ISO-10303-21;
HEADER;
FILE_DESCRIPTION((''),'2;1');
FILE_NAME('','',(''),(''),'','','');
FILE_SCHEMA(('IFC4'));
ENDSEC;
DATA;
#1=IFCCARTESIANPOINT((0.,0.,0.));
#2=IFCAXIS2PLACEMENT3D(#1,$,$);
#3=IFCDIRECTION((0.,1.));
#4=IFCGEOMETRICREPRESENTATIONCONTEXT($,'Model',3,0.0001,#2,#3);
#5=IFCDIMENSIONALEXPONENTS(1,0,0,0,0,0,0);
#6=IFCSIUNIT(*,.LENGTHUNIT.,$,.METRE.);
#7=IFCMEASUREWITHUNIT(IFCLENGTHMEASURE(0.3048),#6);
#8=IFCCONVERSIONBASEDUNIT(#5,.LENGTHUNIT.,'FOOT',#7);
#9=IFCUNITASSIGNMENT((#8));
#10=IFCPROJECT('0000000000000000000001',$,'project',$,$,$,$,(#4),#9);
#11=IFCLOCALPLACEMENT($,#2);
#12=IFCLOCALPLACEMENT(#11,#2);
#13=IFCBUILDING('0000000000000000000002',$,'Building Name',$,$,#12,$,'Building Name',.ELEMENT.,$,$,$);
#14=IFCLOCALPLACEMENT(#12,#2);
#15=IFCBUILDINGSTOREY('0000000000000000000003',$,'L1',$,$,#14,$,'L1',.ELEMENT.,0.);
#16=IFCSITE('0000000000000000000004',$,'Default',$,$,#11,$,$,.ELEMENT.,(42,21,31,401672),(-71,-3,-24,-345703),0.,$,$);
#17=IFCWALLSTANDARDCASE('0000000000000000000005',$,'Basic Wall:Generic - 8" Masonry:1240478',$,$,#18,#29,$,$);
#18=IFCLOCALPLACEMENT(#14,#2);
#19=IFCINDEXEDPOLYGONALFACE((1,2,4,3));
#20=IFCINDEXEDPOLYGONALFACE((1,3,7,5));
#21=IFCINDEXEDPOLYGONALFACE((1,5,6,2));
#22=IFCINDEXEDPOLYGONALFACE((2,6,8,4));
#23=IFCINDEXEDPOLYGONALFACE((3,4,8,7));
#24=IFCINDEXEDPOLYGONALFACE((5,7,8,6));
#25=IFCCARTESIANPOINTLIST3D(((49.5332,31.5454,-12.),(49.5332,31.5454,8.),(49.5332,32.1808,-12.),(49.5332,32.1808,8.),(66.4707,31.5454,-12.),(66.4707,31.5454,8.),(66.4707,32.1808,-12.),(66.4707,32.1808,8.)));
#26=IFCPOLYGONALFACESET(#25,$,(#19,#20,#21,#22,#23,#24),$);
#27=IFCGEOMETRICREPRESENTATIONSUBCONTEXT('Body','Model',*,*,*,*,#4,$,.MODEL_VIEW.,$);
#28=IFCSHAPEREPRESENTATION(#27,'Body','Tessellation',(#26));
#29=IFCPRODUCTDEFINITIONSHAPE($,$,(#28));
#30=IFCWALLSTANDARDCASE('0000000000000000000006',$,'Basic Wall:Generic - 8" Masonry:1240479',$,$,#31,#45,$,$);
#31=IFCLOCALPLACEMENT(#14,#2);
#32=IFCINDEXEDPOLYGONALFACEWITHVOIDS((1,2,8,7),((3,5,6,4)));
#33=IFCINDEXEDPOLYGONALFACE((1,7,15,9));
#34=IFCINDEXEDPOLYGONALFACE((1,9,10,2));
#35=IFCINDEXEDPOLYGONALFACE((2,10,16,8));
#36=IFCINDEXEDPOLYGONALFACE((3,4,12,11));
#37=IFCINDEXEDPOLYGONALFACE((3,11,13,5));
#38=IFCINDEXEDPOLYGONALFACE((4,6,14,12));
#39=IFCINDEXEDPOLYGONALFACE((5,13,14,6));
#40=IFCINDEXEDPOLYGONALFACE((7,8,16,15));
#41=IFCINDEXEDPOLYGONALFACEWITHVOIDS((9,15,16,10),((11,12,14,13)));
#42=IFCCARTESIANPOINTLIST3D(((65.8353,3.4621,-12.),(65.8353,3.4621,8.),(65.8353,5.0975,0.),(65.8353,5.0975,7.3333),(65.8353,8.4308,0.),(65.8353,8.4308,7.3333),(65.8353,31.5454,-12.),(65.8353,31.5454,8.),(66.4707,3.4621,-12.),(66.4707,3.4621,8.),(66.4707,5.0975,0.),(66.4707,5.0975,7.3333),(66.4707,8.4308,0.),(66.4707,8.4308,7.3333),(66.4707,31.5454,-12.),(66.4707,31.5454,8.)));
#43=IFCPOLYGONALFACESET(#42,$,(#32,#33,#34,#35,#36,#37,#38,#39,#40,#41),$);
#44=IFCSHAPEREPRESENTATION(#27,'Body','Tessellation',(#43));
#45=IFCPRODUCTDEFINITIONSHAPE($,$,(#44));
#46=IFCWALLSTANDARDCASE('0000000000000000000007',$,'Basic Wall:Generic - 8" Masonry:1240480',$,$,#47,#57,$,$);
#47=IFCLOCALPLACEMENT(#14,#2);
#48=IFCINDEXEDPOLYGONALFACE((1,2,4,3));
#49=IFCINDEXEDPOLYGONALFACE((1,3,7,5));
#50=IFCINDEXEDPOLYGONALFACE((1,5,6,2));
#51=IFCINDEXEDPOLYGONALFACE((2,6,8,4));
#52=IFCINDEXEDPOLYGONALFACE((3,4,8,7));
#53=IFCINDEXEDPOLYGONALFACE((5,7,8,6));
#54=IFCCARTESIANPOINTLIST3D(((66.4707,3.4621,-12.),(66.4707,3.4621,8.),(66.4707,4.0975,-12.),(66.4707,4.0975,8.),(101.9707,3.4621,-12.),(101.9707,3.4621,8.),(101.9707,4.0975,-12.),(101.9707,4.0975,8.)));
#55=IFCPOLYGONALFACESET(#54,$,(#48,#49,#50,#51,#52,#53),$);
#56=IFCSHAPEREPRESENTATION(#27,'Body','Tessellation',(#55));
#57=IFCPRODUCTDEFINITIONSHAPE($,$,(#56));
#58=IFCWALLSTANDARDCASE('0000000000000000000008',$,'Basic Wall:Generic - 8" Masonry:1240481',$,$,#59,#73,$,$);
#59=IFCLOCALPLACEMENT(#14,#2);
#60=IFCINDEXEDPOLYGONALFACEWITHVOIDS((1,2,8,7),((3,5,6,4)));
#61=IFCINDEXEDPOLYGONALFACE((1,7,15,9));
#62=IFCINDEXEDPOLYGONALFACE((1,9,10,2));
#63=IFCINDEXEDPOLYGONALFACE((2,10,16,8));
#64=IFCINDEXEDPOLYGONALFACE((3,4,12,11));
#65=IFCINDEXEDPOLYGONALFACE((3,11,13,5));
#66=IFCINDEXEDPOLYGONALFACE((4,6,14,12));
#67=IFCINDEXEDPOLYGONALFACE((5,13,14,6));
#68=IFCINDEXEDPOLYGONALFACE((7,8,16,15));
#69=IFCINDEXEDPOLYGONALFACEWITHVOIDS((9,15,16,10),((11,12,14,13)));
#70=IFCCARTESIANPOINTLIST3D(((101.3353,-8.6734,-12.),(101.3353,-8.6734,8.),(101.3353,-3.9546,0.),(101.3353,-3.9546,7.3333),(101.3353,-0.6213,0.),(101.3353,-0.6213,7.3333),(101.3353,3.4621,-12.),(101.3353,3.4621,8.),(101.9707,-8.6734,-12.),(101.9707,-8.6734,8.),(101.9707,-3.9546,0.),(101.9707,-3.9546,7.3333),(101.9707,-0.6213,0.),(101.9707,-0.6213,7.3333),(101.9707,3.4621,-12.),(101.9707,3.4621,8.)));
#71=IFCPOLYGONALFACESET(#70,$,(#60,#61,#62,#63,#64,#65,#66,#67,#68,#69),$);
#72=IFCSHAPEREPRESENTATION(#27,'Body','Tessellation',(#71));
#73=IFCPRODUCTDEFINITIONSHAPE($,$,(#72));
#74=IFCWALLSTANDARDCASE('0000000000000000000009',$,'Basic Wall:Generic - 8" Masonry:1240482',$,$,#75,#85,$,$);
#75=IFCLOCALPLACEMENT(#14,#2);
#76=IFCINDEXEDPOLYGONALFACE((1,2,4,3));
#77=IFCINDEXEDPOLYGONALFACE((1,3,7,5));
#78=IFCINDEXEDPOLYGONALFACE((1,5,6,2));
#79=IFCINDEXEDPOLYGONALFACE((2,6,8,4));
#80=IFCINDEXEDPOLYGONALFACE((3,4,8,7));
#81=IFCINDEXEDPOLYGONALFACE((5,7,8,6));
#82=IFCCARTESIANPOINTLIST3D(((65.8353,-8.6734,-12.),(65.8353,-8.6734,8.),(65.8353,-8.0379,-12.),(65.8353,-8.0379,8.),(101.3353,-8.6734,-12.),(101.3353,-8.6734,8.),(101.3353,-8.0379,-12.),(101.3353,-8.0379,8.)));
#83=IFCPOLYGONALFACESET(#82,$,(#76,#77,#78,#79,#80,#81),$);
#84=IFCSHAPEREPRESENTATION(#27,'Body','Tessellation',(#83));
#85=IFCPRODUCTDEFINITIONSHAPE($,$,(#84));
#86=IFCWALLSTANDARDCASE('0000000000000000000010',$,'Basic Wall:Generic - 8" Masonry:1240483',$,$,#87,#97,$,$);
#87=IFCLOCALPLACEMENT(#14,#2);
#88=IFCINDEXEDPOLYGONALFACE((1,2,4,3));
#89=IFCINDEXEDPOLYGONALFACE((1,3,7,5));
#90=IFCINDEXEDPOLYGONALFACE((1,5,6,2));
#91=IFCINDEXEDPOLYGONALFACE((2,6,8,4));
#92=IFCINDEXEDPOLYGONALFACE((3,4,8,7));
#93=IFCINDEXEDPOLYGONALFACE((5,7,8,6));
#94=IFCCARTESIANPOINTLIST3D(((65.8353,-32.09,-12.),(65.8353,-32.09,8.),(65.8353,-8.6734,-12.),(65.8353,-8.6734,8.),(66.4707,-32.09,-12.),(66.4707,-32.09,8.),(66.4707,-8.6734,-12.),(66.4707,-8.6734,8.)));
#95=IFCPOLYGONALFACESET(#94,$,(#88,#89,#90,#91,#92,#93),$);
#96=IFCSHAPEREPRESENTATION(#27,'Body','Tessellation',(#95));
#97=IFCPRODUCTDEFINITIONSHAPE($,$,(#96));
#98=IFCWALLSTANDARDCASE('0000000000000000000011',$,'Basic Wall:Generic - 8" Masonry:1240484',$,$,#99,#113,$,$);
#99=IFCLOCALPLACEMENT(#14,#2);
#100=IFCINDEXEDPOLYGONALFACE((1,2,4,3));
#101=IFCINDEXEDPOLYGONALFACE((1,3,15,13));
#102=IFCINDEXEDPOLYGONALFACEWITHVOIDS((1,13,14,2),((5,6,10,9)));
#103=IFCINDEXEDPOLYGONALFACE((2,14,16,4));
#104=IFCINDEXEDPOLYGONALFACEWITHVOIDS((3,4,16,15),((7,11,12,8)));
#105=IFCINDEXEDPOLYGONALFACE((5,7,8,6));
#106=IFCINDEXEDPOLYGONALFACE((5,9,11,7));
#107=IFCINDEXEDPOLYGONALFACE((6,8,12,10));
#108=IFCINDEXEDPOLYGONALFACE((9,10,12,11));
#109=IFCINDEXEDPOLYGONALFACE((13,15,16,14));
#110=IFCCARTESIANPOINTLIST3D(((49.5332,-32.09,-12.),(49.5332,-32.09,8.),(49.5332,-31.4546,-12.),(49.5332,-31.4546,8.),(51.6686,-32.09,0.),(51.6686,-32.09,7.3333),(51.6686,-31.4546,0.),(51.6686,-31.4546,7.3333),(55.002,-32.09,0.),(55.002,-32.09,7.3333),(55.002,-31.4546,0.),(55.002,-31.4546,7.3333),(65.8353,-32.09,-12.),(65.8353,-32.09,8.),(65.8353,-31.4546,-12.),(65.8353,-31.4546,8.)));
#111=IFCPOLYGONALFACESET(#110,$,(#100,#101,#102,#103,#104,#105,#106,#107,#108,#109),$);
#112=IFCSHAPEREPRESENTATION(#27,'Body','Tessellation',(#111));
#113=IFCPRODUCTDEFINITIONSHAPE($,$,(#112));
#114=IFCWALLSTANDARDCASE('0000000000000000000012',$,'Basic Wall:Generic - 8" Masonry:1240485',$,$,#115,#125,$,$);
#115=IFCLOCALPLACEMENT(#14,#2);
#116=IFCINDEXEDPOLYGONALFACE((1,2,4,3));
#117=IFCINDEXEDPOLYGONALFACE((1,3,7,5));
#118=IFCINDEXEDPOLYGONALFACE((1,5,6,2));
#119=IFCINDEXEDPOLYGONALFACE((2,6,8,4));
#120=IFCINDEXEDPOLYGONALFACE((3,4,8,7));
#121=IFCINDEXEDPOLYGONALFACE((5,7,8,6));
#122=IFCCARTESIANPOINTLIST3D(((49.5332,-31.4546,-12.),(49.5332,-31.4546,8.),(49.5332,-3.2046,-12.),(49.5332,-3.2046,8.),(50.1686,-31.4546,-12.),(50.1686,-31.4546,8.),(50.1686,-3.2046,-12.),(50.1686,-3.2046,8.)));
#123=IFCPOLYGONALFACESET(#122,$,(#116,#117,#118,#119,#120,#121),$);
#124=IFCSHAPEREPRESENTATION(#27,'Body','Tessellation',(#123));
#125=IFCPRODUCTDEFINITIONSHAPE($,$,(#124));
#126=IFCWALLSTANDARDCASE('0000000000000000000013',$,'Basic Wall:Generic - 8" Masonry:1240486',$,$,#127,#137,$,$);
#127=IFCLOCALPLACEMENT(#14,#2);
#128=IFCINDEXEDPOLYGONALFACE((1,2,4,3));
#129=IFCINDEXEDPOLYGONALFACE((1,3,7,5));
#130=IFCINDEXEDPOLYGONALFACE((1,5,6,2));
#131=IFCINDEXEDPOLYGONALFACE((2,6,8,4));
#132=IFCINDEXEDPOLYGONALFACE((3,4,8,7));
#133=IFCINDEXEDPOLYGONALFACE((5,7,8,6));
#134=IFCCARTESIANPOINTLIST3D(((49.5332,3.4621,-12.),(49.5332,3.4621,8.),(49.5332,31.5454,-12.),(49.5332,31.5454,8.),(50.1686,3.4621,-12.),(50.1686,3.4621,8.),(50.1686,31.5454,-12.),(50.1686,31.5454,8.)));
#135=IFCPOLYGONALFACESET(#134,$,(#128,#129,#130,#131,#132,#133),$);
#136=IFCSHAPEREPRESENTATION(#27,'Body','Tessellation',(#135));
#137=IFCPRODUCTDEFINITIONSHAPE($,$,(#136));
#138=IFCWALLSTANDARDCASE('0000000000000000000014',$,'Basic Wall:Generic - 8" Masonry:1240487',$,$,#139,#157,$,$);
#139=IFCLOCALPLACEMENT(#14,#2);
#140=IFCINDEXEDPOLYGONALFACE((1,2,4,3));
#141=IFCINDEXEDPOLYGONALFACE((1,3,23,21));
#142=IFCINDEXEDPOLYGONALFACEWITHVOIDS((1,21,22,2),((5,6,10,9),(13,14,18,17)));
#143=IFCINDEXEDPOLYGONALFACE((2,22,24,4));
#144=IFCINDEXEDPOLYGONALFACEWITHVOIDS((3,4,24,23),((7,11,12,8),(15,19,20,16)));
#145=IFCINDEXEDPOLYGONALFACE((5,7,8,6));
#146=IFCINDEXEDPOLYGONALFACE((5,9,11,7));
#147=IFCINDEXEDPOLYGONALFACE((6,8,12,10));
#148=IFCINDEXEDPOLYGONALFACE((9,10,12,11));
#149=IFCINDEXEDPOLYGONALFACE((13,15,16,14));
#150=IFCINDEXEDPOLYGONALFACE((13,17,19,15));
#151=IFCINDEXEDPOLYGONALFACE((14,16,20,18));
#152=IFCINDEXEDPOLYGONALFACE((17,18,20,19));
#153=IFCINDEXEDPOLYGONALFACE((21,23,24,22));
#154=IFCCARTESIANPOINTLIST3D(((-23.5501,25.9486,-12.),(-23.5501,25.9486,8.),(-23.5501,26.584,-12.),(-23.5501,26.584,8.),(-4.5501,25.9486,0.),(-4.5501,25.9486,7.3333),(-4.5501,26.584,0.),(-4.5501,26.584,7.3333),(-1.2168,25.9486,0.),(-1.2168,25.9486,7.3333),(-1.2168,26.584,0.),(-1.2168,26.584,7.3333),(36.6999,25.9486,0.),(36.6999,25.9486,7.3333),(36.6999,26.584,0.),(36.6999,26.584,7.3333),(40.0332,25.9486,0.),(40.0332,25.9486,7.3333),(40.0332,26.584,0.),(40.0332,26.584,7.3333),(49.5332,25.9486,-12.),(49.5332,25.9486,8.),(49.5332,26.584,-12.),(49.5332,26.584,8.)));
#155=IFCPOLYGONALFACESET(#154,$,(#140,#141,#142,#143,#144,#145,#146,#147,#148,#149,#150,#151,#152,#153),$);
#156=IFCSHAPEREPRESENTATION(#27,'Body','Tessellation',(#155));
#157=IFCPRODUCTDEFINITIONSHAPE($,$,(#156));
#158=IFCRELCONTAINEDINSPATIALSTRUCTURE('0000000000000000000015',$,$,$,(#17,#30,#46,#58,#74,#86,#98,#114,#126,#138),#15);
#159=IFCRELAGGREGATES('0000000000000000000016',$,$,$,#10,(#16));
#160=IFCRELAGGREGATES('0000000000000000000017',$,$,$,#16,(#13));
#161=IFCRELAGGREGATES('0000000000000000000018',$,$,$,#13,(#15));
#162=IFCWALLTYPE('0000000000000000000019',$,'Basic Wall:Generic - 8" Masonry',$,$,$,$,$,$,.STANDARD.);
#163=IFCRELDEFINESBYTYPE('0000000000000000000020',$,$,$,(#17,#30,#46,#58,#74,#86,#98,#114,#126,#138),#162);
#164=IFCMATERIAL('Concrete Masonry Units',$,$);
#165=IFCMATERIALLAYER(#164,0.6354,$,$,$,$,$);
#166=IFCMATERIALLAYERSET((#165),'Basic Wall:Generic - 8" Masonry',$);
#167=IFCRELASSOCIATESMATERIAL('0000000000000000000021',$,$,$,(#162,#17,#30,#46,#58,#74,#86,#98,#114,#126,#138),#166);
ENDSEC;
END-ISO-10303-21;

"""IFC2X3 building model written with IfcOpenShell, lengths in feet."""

from ifc_helpers import new_model, entity, si_unit, converted_unit, direction, frame, frame_2d, origin, place, context, subcontext, project, spatial, rectangle, extrude, material, layer, layer_set, layer_usage, type_object, element, save


model = new_model("IFC2X3")

# Units and contexts
model_context = context("Model", 3, precision=0.0001, world=origin(), true_north=direction((0.0, 1.0)))
body_context = subcontext(model_context, "Body", "Model", "MODEL_VIEW")
ifc_project = project(units=[converted_unit("LENGTHUNIT", "FOOT", entity("IfcLengthMeasure", 0.3048), si_unit("LENGTHUNIT", "METRE"), dimensions=[1, 0, 0, 0, 0, 0, 0])], contexts=[model_context])

# Site, building, storey
site_placement = place(None, origin())
site = spatial("IfcSite", under=ifc_project, at=site_placement, Name="Default", CompositionType="ELEMENT", RefLatitude=(42, 21, 31, 401672), RefLongitude=(-71, -3, -24, -345703), RefElevation=0.0)
building_placement = place(site_placement, origin())
building = spatial("IfcBuilding", under=site, at=building_placement, Name="Building Name", LongName="Building Name", CompositionType="ELEMENT")
storey_placement = place(building_placement, origin())
storey = spatial("IfcBuildingStorey", under=building, at=storey_placement, Name="L1", LongName="L1", CompositionType="ELEMENT", Elevation=0.0)

# Wall
ifc_material = material(Name="Concrete Masonry Units")
ifc_layer = layer(ifc_material, 0.6354)
ifc_layer_set = layer_set([ifc_layer], Name="Basic Wall:Generic - 8\" Masonry")
ifc_layer_usage_1 = layer_usage(ifc_layer_set, "AXIS2", "NEGATIVE", 0.3177)
wall_type = type_object("IfcWallType", Name="Basic Wall:Generic - 8\" Masonry", PredefinedType="STANDARD", material=ifc_layer_set)
wall_1_placement = place(storey_placement, frame((49.5332, 31.8631, -12.0)))
element("IfcWallStandardCase", 1, at=wall_1_placement, inside=storey, type_object=wall_type, material=ifc_layer_usage_1, Name="Basic Wall:Generic - 8\" Masonry:1240478", context=body_context, shape_type="SweptSolid", body=[
    extrude(rectangle(XDim=16.9375, YDim=0.6354, at=frame_2d((8.4688, 0.0), x_axis=(-1.0, 0.0))), origin(), (0.0, 0.0, 1.0), 20.0),
])

# Wall, opening
ifc_layer_usage_2 = layer_usage(ifc_layer_set, "AXIS2", "NEGATIVE", 0.3177)
wall_2_placement = place(storey_placement, frame((66.153, 31.5454, -12.0), z_axis=(0.0, 0.0, 1.0), x_axis=(0.0, -1.0, 0.0)))
wall_2 = element("IfcWallStandardCase", 2, at=wall_2_placement, inside=storey, type_object=wall_type, material=ifc_layer_usage_2, Name="Basic Wall:Generic - 8\" Masonry:1240479", context=body_context, shape_type="SweptSolid", body=[
    extrude(rectangle(XDim=28.0833, YDim=0.6354, at=frame_2d((14.0417, 0.0), x_axis=(-1.0, 0.0))), origin(), (0.0, 0.0, 1.0), 20.0),
])
opening_1_placement = place(wall_2_placement, frame((23.1146, -0.3177, 12.0)))
element("IfcOpeningElement", 3, at=opening_1_placement, cuts=wall_2, ObjectType="Opening", context=body_context, shape_type="SweptSolid", body=[
    extrude(rectangle(XDim=7.3333, YDim=3.3333, at=frame_2d((3.6667, 1.6667), x_axis=(1.0, 0.0))), frame((0.0, 0.0, 0.0), z_axis=(0.0, 1.0, 0.0), x_axis=(0.0, 0.0, 1.0)), (0.0, 0.0, 1.0), 0.6354),
])

# Wall
ifc_layer_usage_3 = layer_usage(ifc_layer_set, "AXIS2", "NEGATIVE", 0.3177)
wall_3_placement = place(storey_placement, frame((66.4707, 3.7798, -12.0)))
element("IfcWallStandardCase", 4, at=wall_3_placement, inside=storey, type_object=wall_type, material=ifc_layer_usage_3, Name="Basic Wall:Generic - 8\" Masonry:1240480", context=body_context, shape_type="SweptSolid", body=[
    extrude(rectangle(XDim=35.5, YDim=0.6354, at=frame_2d((17.75, 0.0), x_axis=(-1.0, 0.0))), origin(), (0.0, 0.0, 1.0), 20.0),
])

# Wall, opening
ifc_layer_usage_4 = layer_usage(ifc_layer_set, "AXIS2", "NEGATIVE", 0.3177)
wall_4_placement = place(storey_placement, frame((101.653, 3.4621, -12.0), z_axis=(0.0, 0.0, 1.0), x_axis=(0.0, -1.0, 0.0)))
wall_4 = element("IfcWallStandardCase", 5, at=wall_4_placement, inside=storey, type_object=wall_type, material=ifc_layer_usage_4, Name="Basic Wall:Generic - 8\" Masonry:1240481", context=body_context, shape_type="SweptSolid", body=[
    extrude(rectangle(XDim=12.1354, YDim=0.6354, at=frame_2d((6.0677, 0.0), x_axis=(-1.0, 0.0))), origin(), (0.0, 0.0, 1.0), 20.0),
])
opening_2_placement = place(wall_4_placement, frame((4.0833, -0.3177, 12.0)))
element("IfcOpeningElement", 6, at=opening_2_placement, cuts=wall_4, ObjectType="Opening", context=body_context, shape_type="SweptSolid", body=[
    extrude(rectangle(XDim=7.3333, YDim=3.3333, at=frame_2d((3.6667, 1.6667), x_axis=(1.0, 0.0))), frame((0.0, 0.0, 0.0), z_axis=(0.0, 1.0, 0.0), x_axis=(0.0, 0.0, 1.0)), (0.0, 0.0, 1.0), 0.6354),
])

# Walls
ifc_layer_usage_5 = layer_usage(ifc_layer_set, "AXIS2", "NEGATIVE", 0.3177)
wall_5_placement = place(storey_placement, frame((101.3353, -8.3556, -12.0), z_axis=(0.0, 0.0, 1.0), x_axis=(-1.0, 0.0, 0.0)))
element("IfcWallStandardCase", 7, at=wall_5_placement, inside=storey, type_object=wall_type, material=ifc_layer_usage_5, Name="Basic Wall:Generic - 8\" Masonry:1240482", context=body_context, shape_type="SweptSolid", body=[
    extrude(rectangle(XDim=35.5, YDim=0.6354, at=frame_2d((17.75, 0.0), x_axis=(-1.0, 0.0))), origin(), (0.0, 0.0, 1.0), 20.0),
])
ifc_layer_usage_6 = layer_usage(ifc_layer_set, "AXIS2", "NEGATIVE", 0.3177)
wall_6_placement = place(storey_placement, frame((66.153, -8.6734, -12.0), z_axis=(0.0, 0.0, 1.0), x_axis=(0.0, -1.0, 0.0)))
element("IfcWallStandardCase", 8, at=wall_6_placement, inside=storey, type_object=wall_type, material=ifc_layer_usage_6, Name="Basic Wall:Generic - 8\" Masonry:1240483", context=body_context, shape_type="SweptSolid", body=[
    extrude(rectangle(XDim=23.4167, YDim=0.6354, at=frame_2d((11.7083, 0.0), x_axis=(-1.0, 0.0))), origin(), (0.0, 0.0, 1.0), 20.0),
])

# Wall, opening
ifc_layer_usage_7 = layer_usage(ifc_layer_set, "AXIS2", "NEGATIVE", 0.3177)
wall_7_placement = place(storey_placement, frame((65.8353, -31.7723, -12.0), z_axis=(0.0, 0.0, 1.0), x_axis=(-1.0, 0.0, 0.0)))
wall_7 = element("IfcWallStandardCase", 9, at=wall_7_placement, inside=storey, type_object=wall_type, material=ifc_layer_usage_7, Name="Basic Wall:Generic - 8\" Masonry:1240484", context=body_context, shape_type="SweptSolid", body=[
    extrude(rectangle(XDim=16.3021, YDim=0.6354, at=frame_2d((8.151, 0.0), x_axis=(-1.0, 0.0))), origin(), (0.0, 0.0, 1.0), 20.0),
])
opening_3_placement = place(wall_7_placement, frame((10.8333, -0.3177, 12.0)))
element("IfcOpeningElement", 10, at=opening_3_placement, cuts=wall_7, ObjectType="Opening", context=body_context, shape_type="SweptSolid", body=[
    extrude(rectangle(XDim=7.3333, YDim=3.3333, at=frame_2d((3.6667, 1.6667), x_axis=(1.0, 0.0))), frame((0.0, 0.0, 0.0), z_axis=(0.0, 1.0, 0.0), x_axis=(0.0, 0.0, 1.0)), (0.0, 0.0, 1.0), 0.6354),
])

# Walls
ifc_layer_usage_8 = layer_usage(ifc_layer_set, "AXIS2", "NEGATIVE", 0.3177)
wall_8_placement = place(storey_placement, frame((49.8509, -31.4546, -12.0), z_axis=(0.0, 0.0, 1.0), x_axis=(0.0, 1.0, 0.0)))
element("IfcWallStandardCase", 11, at=wall_8_placement, inside=storey, type_object=wall_type, material=ifc_layer_usage_8, Name="Basic Wall:Generic - 8\" Masonry:1240485", context=body_context, shape_type="SweptSolid", body=[
    extrude(rectangle(XDim=28.25, YDim=0.6354, at=frame_2d((14.125, 0.0), x_axis=(-1.0, 0.0))), origin(), (0.0, 0.0, 1.0), 20.0),
])
ifc_layer_usage_9 = layer_usage(ifc_layer_set, "AXIS2", "NEGATIVE", 0.3177)
wall_9_placement = place(storey_placement, frame((49.8509, 31.5454, -12.0), z_axis=(0.0, 0.0, 1.0), x_axis=(0.0, -1.0, 0.0)))
element("IfcWallStandardCase", 12, at=wall_9_placement, inside=storey, type_object=wall_type, material=ifc_layer_usage_9, Name="Basic Wall:Generic - 8\" Masonry:1240486", context=body_context, shape_type="SweptSolid", body=[
    extrude(rectangle(XDim=28.0833, YDim=0.6354, at=frame_2d((14.0417, 0.0), x_axis=(-1.0, 0.0))), origin(), (0.0, 0.0, 1.0), 20.0),
])

# Wall, openings
ifc_layer_usage_10 = layer_usage(ifc_layer_set, "AXIS2", "NEGATIVE", 0.3177)
wall_10_placement = place(storey_placement, frame((49.5332, 26.2663, -12.0), z_axis=(0.0, 0.0, 1.0), x_axis=(-1.0, 0.0, 0.0)))
wall_10 = element("IfcWallStandardCase", 13, at=wall_10_placement, inside=storey, type_object=wall_type, material=ifc_layer_usage_10, Name="Basic Wall:Generic - 8\" Masonry:1240487", context=body_context, shape_type="SweptSolid", body=[
    extrude(rectangle(XDim=73.0833, YDim=0.6354, at=frame_2d((36.5417, 0.0), x_axis=(-1.0, 0.0))), origin(), (0.0, 0.0, 1.0), 20.0),
])
opening_4_placement = place(wall_10_placement, frame((54.0833, 0.3177, 12.0)))
element("IfcOpeningElement", 14, at=opening_4_placement, cuts=wall_10, ObjectType="Opening", context=body_context, shape_type="SweptSolid", body=[
    extrude(rectangle(XDim=7.3333, YDim=3.3333, at=frame_2d((3.6667, 1.6667), x_axis=(1.0, 0.0))), frame((0.0, 0.0, 0.0), z_axis=(0.0, -1.0, 0.0), x_axis=(0.0, 0.0, 1.0)), (0.0, 0.0, 1.0), 0.6354),
])
opening_5_placement = place(wall_10_placement, frame((12.8333, 0.3177, 12.0)))
element("IfcOpeningElement", 15, at=opening_5_placement, cuts=wall_10, ObjectType="Opening", context=body_context, shape_type="SweptSolid", body=[
    extrude(rectangle(XDim=7.3333, YDim=3.3333, at=frame_2d((3.6667, 1.6667), x_axis=(1.0, 0.0))), frame((0.0, 0.0, 0.0), z_axis=(0.0, -1.0, 0.0), x_axis=(0.0, 0.0, 1.0)), (0.0, 0.0, 1.0), 0.6354),
])

save(model, "model.ifc")
